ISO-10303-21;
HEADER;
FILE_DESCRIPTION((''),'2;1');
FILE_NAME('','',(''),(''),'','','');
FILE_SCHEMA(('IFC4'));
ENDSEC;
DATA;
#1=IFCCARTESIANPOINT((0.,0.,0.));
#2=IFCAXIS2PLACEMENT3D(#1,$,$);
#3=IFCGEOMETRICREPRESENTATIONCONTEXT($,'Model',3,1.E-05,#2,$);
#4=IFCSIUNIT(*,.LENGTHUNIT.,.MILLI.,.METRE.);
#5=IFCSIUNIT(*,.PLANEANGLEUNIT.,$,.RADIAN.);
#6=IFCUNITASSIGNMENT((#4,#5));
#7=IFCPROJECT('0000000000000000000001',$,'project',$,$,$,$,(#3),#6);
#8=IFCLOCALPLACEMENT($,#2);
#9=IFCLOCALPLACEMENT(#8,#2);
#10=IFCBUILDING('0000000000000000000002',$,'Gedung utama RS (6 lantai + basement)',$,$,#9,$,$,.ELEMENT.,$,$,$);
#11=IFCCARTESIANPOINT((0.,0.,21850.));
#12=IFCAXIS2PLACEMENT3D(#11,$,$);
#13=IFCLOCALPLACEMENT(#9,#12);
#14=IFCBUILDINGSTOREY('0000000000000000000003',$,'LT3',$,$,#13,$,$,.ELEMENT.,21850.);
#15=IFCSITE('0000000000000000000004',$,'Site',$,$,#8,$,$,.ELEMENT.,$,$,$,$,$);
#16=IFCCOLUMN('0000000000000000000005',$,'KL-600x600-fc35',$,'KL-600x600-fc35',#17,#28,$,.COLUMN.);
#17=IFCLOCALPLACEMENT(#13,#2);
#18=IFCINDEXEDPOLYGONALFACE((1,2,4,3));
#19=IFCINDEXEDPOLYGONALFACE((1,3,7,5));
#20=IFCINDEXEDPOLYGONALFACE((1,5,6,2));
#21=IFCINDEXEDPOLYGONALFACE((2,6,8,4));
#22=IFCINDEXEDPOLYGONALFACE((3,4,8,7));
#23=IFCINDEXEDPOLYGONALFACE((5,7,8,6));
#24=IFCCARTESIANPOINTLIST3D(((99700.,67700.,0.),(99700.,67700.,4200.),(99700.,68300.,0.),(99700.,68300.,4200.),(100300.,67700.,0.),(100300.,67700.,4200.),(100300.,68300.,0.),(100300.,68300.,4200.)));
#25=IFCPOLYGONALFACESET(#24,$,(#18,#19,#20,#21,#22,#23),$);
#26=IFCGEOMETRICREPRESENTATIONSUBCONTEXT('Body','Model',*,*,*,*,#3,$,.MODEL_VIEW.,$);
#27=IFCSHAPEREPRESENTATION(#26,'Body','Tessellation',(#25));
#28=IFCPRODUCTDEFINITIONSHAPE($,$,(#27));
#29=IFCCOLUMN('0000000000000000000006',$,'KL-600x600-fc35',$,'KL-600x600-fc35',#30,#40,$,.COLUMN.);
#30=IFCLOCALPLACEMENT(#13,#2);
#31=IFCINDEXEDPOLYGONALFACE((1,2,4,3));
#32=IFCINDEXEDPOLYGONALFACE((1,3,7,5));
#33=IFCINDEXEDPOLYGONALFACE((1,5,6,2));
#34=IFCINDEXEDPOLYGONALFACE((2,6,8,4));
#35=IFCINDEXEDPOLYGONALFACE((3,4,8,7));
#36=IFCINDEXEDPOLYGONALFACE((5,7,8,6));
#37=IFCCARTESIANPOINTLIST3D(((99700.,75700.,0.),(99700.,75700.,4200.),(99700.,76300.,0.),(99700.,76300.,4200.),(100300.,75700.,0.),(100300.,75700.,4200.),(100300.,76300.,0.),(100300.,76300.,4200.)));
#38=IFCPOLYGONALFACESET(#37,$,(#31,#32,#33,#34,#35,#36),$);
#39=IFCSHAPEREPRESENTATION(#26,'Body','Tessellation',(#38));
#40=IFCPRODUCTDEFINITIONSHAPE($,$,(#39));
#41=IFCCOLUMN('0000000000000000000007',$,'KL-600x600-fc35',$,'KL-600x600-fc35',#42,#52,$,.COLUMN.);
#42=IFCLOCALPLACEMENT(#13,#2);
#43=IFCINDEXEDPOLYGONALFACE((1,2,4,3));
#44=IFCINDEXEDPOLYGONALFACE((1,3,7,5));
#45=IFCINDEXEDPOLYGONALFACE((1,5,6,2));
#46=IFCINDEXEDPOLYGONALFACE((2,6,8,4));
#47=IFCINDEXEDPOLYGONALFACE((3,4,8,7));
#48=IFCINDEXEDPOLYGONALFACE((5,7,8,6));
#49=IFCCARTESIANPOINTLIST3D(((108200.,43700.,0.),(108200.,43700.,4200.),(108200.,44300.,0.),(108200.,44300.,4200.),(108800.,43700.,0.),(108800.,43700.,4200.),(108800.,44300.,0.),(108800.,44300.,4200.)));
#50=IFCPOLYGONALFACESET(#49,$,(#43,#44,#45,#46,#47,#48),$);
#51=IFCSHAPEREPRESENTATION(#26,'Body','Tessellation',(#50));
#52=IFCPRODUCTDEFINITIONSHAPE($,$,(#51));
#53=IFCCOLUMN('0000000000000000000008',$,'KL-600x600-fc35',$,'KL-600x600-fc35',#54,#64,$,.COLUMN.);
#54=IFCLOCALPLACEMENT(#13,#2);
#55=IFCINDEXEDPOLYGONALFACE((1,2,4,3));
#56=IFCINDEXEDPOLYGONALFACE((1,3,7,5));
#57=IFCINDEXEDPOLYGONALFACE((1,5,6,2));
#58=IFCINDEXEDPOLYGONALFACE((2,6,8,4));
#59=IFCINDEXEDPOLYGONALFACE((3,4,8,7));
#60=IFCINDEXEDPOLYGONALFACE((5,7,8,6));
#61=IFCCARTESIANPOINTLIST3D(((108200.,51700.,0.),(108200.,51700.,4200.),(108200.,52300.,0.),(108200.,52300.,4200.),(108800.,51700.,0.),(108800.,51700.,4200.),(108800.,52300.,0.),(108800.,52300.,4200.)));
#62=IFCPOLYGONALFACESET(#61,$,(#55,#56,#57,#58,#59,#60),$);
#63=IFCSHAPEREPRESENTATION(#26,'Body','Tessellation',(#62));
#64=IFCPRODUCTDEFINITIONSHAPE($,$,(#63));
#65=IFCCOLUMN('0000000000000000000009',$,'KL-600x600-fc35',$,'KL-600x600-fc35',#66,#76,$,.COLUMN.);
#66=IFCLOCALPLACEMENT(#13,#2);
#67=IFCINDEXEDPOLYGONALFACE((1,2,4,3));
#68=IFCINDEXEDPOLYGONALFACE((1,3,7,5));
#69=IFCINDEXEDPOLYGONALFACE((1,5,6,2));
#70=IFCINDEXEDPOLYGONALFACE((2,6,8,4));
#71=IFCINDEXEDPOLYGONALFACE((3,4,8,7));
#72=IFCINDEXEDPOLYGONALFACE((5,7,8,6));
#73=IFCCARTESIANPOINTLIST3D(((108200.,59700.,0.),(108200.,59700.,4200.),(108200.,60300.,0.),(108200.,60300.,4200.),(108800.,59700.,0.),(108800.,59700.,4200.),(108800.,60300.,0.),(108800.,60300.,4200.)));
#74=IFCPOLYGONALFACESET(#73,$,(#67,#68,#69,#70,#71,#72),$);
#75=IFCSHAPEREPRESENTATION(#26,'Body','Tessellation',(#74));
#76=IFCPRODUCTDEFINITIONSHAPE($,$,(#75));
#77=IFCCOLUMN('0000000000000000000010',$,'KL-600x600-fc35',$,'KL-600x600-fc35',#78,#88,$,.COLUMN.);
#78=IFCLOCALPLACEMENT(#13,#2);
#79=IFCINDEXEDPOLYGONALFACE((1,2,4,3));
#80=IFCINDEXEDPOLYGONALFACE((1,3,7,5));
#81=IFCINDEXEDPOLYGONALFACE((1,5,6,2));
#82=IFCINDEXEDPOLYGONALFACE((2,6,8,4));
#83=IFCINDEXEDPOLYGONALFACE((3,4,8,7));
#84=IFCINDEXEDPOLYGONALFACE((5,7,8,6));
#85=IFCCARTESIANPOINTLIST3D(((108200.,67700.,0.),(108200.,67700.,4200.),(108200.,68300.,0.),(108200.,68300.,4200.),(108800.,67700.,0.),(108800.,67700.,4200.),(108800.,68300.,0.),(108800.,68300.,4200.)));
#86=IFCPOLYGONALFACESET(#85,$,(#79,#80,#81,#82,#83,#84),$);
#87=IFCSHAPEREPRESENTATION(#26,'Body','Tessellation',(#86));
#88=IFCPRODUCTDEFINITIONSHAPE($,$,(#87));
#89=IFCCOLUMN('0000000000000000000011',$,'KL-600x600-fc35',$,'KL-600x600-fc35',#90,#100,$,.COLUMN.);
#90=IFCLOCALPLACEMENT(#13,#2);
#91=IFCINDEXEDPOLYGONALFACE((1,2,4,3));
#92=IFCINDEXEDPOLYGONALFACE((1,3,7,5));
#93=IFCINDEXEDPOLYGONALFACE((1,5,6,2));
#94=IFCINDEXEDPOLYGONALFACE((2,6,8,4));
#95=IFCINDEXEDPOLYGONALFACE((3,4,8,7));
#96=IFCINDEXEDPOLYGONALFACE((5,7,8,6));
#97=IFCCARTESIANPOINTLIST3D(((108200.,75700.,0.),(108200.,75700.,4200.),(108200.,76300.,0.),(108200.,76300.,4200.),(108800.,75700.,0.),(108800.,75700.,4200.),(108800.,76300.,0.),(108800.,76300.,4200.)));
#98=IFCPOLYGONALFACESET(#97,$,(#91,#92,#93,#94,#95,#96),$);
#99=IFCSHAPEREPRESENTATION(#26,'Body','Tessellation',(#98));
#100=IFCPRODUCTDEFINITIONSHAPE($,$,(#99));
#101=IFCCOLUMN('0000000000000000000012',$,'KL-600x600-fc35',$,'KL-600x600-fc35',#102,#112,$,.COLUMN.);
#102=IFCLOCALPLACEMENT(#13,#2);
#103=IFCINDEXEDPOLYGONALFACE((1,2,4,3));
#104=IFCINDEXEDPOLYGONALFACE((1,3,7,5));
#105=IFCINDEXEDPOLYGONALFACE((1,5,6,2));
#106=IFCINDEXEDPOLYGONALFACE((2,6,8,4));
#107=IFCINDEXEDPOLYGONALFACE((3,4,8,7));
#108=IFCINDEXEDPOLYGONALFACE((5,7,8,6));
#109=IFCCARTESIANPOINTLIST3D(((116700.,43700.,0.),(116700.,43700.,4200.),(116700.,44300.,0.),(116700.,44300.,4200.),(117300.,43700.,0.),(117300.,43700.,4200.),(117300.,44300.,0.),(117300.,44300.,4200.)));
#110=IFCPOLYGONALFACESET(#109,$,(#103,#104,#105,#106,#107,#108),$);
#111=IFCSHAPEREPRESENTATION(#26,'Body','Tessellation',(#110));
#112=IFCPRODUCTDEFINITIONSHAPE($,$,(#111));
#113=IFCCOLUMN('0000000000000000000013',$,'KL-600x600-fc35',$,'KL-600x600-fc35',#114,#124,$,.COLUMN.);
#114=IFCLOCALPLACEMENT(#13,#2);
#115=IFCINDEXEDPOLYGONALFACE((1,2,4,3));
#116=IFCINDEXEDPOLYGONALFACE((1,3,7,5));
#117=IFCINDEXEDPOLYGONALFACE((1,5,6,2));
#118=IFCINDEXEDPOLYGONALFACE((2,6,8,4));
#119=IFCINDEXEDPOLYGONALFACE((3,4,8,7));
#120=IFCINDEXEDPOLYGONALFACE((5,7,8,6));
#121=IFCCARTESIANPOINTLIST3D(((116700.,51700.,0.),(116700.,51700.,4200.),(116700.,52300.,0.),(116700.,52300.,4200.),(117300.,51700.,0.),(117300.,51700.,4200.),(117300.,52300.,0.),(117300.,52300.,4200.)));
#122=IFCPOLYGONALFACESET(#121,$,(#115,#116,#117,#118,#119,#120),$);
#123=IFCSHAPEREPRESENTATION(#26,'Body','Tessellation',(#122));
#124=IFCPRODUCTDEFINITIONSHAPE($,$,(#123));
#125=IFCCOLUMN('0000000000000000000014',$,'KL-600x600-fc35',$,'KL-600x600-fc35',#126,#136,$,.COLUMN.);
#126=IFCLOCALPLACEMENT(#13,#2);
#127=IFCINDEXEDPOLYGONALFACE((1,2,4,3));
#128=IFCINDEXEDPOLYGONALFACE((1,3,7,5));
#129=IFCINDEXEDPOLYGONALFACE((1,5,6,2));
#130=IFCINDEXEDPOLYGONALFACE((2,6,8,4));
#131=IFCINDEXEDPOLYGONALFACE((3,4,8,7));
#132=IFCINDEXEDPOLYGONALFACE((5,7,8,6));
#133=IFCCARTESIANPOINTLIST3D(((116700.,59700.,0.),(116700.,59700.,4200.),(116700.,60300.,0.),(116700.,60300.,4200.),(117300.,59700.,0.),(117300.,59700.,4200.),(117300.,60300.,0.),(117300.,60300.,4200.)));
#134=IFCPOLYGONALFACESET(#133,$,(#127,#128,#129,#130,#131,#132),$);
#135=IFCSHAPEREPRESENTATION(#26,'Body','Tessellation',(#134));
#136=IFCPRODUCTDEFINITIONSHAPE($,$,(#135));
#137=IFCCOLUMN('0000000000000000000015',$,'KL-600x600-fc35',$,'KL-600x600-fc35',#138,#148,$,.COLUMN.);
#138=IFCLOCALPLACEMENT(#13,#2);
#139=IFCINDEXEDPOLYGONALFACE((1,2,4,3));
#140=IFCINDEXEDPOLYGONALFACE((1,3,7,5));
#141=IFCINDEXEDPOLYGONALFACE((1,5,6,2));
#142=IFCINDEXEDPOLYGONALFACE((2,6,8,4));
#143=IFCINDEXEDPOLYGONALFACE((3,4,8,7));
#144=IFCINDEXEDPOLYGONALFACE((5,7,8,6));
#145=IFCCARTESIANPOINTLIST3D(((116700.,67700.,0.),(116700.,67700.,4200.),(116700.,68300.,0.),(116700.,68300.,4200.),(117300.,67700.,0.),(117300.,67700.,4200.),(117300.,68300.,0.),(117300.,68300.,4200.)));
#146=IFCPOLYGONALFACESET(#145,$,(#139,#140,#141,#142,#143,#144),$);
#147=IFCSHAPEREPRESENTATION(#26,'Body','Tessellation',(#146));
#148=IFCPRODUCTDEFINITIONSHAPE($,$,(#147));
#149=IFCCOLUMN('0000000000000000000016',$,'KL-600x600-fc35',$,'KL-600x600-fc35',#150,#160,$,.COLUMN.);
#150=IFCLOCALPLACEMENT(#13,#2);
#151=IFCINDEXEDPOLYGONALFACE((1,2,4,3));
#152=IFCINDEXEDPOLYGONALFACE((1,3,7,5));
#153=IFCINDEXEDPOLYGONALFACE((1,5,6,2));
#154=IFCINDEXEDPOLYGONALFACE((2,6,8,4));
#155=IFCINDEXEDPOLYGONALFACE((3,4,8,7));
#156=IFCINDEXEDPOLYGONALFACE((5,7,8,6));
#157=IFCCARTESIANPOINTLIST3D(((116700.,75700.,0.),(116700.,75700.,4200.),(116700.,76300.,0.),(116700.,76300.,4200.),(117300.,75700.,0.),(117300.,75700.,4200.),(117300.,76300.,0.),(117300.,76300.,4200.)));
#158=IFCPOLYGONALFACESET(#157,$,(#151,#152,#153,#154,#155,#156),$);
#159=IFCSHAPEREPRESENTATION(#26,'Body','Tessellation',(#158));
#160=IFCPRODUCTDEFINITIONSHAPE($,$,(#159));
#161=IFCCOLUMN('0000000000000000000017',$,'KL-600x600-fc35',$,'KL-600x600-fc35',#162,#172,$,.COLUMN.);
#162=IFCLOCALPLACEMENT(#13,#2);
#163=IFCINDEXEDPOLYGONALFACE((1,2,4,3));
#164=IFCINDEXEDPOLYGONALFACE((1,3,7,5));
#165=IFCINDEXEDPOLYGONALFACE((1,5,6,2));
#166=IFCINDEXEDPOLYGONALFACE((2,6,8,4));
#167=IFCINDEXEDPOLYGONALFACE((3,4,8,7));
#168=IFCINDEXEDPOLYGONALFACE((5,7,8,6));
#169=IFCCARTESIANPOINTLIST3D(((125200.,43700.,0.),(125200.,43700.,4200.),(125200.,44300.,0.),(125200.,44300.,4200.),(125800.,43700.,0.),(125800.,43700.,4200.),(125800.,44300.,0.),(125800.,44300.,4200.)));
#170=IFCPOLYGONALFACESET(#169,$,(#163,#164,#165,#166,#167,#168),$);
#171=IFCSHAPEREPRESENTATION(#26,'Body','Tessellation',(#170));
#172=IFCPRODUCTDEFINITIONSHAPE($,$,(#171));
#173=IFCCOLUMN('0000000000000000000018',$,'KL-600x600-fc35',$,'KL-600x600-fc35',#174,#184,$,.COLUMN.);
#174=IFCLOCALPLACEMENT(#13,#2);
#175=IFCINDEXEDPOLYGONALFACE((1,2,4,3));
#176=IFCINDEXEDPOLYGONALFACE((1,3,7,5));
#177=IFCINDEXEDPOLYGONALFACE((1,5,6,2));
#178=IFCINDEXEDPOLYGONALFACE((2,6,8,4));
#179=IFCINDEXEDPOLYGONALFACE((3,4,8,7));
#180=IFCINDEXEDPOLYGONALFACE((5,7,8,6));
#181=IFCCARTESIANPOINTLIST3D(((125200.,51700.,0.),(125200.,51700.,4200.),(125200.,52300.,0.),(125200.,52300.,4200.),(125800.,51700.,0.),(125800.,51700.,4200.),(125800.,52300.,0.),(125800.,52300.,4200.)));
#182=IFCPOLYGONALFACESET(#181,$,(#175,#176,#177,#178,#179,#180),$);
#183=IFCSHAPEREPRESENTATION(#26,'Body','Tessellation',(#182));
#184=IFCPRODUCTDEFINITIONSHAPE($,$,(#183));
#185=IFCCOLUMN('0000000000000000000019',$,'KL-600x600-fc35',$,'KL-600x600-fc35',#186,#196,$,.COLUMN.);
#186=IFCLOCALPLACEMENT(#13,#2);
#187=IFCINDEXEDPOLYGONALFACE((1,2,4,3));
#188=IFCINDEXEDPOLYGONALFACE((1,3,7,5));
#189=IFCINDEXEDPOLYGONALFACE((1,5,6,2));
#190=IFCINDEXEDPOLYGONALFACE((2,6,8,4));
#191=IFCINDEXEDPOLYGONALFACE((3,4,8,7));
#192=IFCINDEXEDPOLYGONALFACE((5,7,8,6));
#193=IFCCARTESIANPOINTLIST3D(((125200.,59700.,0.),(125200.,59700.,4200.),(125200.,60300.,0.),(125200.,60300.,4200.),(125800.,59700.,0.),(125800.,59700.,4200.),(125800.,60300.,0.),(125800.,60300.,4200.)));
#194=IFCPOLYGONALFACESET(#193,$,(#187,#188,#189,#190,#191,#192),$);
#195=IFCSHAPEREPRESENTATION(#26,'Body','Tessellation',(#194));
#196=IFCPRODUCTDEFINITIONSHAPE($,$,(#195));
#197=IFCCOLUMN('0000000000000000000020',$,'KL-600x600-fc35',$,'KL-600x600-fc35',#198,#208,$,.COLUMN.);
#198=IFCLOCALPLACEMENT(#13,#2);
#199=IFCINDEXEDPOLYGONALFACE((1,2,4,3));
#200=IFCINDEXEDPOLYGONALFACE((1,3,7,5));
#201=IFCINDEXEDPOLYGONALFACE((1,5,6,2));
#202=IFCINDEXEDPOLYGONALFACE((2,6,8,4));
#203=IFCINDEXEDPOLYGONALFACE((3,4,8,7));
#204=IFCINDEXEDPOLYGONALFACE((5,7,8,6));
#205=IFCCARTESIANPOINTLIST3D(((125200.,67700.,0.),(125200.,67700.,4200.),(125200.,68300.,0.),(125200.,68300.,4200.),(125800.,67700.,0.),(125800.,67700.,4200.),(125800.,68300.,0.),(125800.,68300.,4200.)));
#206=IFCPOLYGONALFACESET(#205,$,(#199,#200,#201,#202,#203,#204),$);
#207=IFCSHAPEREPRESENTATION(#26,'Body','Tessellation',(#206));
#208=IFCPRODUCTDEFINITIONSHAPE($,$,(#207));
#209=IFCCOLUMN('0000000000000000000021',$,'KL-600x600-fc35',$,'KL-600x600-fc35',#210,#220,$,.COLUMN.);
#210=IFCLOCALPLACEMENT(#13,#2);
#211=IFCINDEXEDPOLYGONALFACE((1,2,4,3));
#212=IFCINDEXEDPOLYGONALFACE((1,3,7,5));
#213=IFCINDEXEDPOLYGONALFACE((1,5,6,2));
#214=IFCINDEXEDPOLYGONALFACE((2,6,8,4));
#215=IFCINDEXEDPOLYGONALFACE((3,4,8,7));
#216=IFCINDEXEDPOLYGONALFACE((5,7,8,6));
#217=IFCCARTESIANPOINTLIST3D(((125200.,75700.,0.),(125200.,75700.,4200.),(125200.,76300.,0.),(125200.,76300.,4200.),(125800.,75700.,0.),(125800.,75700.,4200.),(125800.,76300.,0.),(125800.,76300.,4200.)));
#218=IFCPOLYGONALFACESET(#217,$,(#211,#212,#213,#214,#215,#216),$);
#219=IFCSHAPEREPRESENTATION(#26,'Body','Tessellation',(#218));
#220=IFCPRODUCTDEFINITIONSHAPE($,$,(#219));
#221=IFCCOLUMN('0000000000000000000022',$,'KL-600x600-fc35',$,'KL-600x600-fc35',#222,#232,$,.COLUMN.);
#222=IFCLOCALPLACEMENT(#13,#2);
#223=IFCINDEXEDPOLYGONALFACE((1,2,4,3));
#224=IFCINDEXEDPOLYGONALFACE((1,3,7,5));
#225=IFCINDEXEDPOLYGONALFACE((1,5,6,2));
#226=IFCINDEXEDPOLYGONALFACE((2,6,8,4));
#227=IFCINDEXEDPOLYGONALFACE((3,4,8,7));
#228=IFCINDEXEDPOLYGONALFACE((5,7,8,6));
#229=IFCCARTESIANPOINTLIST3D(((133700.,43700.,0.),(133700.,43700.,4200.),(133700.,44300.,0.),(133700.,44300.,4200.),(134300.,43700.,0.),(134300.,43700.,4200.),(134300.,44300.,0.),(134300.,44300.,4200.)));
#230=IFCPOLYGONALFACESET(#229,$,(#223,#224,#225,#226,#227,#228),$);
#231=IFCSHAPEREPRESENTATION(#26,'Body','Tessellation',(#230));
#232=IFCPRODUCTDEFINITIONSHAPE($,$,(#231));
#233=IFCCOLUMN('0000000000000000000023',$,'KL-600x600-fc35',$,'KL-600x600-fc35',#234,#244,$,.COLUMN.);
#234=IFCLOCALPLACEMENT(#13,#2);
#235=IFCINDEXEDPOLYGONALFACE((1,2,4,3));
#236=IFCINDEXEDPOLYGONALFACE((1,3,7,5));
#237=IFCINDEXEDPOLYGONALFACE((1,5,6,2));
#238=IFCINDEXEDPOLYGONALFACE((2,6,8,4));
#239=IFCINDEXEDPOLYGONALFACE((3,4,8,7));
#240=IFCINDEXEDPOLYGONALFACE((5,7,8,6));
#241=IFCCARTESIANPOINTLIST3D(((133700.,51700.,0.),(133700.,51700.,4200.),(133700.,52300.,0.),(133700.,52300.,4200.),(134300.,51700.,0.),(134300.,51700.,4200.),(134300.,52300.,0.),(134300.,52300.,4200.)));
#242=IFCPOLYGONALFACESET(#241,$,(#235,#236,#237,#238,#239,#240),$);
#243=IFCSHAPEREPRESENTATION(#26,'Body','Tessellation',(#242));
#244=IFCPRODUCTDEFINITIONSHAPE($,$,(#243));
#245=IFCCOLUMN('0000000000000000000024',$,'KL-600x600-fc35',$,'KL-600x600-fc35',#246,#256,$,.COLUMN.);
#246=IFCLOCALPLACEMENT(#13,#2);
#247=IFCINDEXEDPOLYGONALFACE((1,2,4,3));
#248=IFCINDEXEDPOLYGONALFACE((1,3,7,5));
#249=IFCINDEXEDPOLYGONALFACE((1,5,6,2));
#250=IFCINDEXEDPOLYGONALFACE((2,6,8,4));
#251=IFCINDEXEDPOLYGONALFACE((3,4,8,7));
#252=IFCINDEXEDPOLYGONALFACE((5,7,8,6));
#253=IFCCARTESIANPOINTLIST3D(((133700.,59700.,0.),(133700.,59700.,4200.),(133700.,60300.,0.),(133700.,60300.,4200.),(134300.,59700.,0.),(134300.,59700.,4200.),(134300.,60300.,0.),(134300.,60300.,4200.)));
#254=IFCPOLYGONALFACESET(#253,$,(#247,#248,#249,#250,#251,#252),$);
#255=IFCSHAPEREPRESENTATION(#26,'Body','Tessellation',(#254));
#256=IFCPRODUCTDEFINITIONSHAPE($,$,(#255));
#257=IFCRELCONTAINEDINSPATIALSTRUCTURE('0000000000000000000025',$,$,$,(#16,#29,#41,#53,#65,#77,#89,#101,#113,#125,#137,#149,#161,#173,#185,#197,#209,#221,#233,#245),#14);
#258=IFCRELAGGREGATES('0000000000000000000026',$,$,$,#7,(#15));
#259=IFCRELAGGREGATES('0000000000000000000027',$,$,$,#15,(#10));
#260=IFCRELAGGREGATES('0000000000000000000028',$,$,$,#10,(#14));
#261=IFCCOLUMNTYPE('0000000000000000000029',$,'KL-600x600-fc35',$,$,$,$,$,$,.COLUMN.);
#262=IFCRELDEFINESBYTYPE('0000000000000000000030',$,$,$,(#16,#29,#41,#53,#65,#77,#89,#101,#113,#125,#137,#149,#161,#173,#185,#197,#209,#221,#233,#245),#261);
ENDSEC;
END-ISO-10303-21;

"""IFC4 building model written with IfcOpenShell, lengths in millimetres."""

from ifc_helpers import new_model, si_unit, frame, origin, origin_2d, place, context, subcontext, project, spatial, rectangle, extrude, material_profile, profile_set, profile_usage, type_object, element, save


model = new_model("IFC4")

# Units and contexts
model_context = context("Model", 3, precision=1e-05, world=origin())
body_context = subcontext(model_context, "Body", "Model", "MODEL_VIEW")
ifc_project = project(units=[si_unit("LENGTHUNIT", "METRE", prefix="MILLI"), si_unit("PLANEANGLEUNIT", "RADIAN")], contexts=[model_context])

# Site, building, storey
site_placement = place(None, origin())
site = spatial("IfcSite", under=ifc_project, at=site_placement, Name="Site", CompositionType="ELEMENT")
building_placement = place(site_placement, origin())
building = spatial("IfcBuilding", under=site, at=building_placement, Name="Gedung utama RS (6 lantai + basement)", CompositionType="ELEMENT")
storey_placement = place(building_placement, frame((0.0, 0.0, 21850.0)))
storey = spatial("IfcBuildingStorey", under=building, at=storey_placement, Name="LT3", CompositionType="ELEMENT", Elevation=21850.0)

# Columns
ifc_material_profile_1 = material_profile(None, rectangle(XDim=600.0, YDim=600.0, at=origin_2d()), Name="KL-600x600-fc35")
ifc_profile_set_1 = profile_set([ifc_material_profile_1], Name="KL-600x600-fc35")
ifc_profile_usage_1 = profile_usage(ifc_profile_set_1, cardinal=5)
column_type = type_object("IfcColumnType", Name="KL-600x600-fc35", PredefinedType="COLUMN", material=ifc_profile_set_1)
for number, where, z_axis, x_axis, name in (
    (1, (100000.0, 68000.0, 0.0), (0.0, 0.0, 1.0), (1.0, 0.0, 0.0), "KL-600x600-fc35"),
    (2, (100000.0, 76000.0, 0.0), (0.0, 0.0, 1.0), (1.0, 0.0, 0.0), "KL-600x600-fc35"),
    (3, (108500.0, 44000.0, 0.0), (0.0, 0.0, 1.0), (1.0, 0.0, 0.0), "KL-600x600-fc35"),
    (4, (108500.0, 52000.0, 0.0), (0.0, 0.0, 1.0), (1.0, 0.0, 0.0), "KL-600x600-fc35"),
    (5, (108500.0, 60000.0, 0.0), (0.0, 0.0, 1.0), (1.0, 0.0, 0.0), "KL-600x600-fc35"),
    (6, (108500.0, 68000.0, 0.0), (0.0, 0.0, 1.0), (1.0, 0.0, 0.0), "KL-600x600-fc35"),
    (7, (108500.0, 76000.0, 0.0), (0.0, 0.0, 1.0), (1.0, 0.0, 0.0), "KL-600x600-fc35"),
    (8, (117000.0, 44000.0, 0.0), (0.0, 0.0, 1.0), (1.0, 0.0, 0.0), "KL-600x600-fc35"),
    (9, (117000.0, 52000.0, 0.0), (0.0, 0.0, 1.0), (1.0, 0.0, 0.0), "KL-600x600-fc35"),
    (10, (117000.0, 60000.0, 0.0), (0.0, 0.0, 1.0), (1.0, 0.0, 0.0), "KL-600x600-fc35"),
    (11, (117000.0, 68000.0, 0.0), (0.0, 0.0, 1.0), (1.0, 0.0, 0.0), "KL-600x600-fc35"),
    (12, (117000.0, 76000.0, 0.0), (0.0, 0.0, 1.0), (1.0, 0.0, 0.0), "KL-600x600-fc35"),
    (13, (125500.0, 44000.0, 0.0), (0.0, 0.0, 1.0), (1.0, 0.0, 0.0), "KL-600x600-fc35"),
    (14, (125500.0, 52000.0, 0.0), (0.0, 0.0, 1.0), (1.0, 0.0, 0.0), "KL-600x600-fc35"),
    (15, (125500.0, 60000.0, 0.0), (0.0, 0.0, 1.0), (1.0, 0.0, 0.0), "KL-600x600-fc35"),
    (16, (125500.0, 68000.0, 0.0), (0.0, 0.0, 1.0), (1.0, 0.0, 0.0), "KL-600x600-fc35"),
    (17, (125500.0, 76000.0, 0.0), (0.0, 0.0, 1.0), (1.0, 0.0, 0.0), "KL-600x600-fc35"),
    (18, (134000.0, 44000.0, 0.0), (0.0, 0.0, 1.0), (1.0, 0.0, 0.0), "KL-600x600-fc35"),
    (19, (134000.0, 52000.0, 0.0), (0.0, 0.0, 1.0), (1.0, 0.0, 0.0), "KL-600x600-fc35"),
    (20, (134000.0, 60000.0, 0.0), (0.0, 0.0, 1.0), (1.0, 0.0, 0.0), "KL-600x600-fc35"),
):
    element("IfcColumn", number, at=place(storey_placement, frame(where, z_axis=z_axis, x_axis=x_axis)), inside=storey, type_object=column_type, material=ifc_profile_usage_1, Name=name, ObjectType="KL-600x600-fc35", PredefinedType="COLUMN", context=body_context, shape_type="SweptSolid", body=[
        extrude(rectangle(XDim=600.0, YDim=600.0, at=origin_2d()), origin(), (0.0, 0.0, 1.0), 4200.0),
    ])

save(model, "model.ifc")
